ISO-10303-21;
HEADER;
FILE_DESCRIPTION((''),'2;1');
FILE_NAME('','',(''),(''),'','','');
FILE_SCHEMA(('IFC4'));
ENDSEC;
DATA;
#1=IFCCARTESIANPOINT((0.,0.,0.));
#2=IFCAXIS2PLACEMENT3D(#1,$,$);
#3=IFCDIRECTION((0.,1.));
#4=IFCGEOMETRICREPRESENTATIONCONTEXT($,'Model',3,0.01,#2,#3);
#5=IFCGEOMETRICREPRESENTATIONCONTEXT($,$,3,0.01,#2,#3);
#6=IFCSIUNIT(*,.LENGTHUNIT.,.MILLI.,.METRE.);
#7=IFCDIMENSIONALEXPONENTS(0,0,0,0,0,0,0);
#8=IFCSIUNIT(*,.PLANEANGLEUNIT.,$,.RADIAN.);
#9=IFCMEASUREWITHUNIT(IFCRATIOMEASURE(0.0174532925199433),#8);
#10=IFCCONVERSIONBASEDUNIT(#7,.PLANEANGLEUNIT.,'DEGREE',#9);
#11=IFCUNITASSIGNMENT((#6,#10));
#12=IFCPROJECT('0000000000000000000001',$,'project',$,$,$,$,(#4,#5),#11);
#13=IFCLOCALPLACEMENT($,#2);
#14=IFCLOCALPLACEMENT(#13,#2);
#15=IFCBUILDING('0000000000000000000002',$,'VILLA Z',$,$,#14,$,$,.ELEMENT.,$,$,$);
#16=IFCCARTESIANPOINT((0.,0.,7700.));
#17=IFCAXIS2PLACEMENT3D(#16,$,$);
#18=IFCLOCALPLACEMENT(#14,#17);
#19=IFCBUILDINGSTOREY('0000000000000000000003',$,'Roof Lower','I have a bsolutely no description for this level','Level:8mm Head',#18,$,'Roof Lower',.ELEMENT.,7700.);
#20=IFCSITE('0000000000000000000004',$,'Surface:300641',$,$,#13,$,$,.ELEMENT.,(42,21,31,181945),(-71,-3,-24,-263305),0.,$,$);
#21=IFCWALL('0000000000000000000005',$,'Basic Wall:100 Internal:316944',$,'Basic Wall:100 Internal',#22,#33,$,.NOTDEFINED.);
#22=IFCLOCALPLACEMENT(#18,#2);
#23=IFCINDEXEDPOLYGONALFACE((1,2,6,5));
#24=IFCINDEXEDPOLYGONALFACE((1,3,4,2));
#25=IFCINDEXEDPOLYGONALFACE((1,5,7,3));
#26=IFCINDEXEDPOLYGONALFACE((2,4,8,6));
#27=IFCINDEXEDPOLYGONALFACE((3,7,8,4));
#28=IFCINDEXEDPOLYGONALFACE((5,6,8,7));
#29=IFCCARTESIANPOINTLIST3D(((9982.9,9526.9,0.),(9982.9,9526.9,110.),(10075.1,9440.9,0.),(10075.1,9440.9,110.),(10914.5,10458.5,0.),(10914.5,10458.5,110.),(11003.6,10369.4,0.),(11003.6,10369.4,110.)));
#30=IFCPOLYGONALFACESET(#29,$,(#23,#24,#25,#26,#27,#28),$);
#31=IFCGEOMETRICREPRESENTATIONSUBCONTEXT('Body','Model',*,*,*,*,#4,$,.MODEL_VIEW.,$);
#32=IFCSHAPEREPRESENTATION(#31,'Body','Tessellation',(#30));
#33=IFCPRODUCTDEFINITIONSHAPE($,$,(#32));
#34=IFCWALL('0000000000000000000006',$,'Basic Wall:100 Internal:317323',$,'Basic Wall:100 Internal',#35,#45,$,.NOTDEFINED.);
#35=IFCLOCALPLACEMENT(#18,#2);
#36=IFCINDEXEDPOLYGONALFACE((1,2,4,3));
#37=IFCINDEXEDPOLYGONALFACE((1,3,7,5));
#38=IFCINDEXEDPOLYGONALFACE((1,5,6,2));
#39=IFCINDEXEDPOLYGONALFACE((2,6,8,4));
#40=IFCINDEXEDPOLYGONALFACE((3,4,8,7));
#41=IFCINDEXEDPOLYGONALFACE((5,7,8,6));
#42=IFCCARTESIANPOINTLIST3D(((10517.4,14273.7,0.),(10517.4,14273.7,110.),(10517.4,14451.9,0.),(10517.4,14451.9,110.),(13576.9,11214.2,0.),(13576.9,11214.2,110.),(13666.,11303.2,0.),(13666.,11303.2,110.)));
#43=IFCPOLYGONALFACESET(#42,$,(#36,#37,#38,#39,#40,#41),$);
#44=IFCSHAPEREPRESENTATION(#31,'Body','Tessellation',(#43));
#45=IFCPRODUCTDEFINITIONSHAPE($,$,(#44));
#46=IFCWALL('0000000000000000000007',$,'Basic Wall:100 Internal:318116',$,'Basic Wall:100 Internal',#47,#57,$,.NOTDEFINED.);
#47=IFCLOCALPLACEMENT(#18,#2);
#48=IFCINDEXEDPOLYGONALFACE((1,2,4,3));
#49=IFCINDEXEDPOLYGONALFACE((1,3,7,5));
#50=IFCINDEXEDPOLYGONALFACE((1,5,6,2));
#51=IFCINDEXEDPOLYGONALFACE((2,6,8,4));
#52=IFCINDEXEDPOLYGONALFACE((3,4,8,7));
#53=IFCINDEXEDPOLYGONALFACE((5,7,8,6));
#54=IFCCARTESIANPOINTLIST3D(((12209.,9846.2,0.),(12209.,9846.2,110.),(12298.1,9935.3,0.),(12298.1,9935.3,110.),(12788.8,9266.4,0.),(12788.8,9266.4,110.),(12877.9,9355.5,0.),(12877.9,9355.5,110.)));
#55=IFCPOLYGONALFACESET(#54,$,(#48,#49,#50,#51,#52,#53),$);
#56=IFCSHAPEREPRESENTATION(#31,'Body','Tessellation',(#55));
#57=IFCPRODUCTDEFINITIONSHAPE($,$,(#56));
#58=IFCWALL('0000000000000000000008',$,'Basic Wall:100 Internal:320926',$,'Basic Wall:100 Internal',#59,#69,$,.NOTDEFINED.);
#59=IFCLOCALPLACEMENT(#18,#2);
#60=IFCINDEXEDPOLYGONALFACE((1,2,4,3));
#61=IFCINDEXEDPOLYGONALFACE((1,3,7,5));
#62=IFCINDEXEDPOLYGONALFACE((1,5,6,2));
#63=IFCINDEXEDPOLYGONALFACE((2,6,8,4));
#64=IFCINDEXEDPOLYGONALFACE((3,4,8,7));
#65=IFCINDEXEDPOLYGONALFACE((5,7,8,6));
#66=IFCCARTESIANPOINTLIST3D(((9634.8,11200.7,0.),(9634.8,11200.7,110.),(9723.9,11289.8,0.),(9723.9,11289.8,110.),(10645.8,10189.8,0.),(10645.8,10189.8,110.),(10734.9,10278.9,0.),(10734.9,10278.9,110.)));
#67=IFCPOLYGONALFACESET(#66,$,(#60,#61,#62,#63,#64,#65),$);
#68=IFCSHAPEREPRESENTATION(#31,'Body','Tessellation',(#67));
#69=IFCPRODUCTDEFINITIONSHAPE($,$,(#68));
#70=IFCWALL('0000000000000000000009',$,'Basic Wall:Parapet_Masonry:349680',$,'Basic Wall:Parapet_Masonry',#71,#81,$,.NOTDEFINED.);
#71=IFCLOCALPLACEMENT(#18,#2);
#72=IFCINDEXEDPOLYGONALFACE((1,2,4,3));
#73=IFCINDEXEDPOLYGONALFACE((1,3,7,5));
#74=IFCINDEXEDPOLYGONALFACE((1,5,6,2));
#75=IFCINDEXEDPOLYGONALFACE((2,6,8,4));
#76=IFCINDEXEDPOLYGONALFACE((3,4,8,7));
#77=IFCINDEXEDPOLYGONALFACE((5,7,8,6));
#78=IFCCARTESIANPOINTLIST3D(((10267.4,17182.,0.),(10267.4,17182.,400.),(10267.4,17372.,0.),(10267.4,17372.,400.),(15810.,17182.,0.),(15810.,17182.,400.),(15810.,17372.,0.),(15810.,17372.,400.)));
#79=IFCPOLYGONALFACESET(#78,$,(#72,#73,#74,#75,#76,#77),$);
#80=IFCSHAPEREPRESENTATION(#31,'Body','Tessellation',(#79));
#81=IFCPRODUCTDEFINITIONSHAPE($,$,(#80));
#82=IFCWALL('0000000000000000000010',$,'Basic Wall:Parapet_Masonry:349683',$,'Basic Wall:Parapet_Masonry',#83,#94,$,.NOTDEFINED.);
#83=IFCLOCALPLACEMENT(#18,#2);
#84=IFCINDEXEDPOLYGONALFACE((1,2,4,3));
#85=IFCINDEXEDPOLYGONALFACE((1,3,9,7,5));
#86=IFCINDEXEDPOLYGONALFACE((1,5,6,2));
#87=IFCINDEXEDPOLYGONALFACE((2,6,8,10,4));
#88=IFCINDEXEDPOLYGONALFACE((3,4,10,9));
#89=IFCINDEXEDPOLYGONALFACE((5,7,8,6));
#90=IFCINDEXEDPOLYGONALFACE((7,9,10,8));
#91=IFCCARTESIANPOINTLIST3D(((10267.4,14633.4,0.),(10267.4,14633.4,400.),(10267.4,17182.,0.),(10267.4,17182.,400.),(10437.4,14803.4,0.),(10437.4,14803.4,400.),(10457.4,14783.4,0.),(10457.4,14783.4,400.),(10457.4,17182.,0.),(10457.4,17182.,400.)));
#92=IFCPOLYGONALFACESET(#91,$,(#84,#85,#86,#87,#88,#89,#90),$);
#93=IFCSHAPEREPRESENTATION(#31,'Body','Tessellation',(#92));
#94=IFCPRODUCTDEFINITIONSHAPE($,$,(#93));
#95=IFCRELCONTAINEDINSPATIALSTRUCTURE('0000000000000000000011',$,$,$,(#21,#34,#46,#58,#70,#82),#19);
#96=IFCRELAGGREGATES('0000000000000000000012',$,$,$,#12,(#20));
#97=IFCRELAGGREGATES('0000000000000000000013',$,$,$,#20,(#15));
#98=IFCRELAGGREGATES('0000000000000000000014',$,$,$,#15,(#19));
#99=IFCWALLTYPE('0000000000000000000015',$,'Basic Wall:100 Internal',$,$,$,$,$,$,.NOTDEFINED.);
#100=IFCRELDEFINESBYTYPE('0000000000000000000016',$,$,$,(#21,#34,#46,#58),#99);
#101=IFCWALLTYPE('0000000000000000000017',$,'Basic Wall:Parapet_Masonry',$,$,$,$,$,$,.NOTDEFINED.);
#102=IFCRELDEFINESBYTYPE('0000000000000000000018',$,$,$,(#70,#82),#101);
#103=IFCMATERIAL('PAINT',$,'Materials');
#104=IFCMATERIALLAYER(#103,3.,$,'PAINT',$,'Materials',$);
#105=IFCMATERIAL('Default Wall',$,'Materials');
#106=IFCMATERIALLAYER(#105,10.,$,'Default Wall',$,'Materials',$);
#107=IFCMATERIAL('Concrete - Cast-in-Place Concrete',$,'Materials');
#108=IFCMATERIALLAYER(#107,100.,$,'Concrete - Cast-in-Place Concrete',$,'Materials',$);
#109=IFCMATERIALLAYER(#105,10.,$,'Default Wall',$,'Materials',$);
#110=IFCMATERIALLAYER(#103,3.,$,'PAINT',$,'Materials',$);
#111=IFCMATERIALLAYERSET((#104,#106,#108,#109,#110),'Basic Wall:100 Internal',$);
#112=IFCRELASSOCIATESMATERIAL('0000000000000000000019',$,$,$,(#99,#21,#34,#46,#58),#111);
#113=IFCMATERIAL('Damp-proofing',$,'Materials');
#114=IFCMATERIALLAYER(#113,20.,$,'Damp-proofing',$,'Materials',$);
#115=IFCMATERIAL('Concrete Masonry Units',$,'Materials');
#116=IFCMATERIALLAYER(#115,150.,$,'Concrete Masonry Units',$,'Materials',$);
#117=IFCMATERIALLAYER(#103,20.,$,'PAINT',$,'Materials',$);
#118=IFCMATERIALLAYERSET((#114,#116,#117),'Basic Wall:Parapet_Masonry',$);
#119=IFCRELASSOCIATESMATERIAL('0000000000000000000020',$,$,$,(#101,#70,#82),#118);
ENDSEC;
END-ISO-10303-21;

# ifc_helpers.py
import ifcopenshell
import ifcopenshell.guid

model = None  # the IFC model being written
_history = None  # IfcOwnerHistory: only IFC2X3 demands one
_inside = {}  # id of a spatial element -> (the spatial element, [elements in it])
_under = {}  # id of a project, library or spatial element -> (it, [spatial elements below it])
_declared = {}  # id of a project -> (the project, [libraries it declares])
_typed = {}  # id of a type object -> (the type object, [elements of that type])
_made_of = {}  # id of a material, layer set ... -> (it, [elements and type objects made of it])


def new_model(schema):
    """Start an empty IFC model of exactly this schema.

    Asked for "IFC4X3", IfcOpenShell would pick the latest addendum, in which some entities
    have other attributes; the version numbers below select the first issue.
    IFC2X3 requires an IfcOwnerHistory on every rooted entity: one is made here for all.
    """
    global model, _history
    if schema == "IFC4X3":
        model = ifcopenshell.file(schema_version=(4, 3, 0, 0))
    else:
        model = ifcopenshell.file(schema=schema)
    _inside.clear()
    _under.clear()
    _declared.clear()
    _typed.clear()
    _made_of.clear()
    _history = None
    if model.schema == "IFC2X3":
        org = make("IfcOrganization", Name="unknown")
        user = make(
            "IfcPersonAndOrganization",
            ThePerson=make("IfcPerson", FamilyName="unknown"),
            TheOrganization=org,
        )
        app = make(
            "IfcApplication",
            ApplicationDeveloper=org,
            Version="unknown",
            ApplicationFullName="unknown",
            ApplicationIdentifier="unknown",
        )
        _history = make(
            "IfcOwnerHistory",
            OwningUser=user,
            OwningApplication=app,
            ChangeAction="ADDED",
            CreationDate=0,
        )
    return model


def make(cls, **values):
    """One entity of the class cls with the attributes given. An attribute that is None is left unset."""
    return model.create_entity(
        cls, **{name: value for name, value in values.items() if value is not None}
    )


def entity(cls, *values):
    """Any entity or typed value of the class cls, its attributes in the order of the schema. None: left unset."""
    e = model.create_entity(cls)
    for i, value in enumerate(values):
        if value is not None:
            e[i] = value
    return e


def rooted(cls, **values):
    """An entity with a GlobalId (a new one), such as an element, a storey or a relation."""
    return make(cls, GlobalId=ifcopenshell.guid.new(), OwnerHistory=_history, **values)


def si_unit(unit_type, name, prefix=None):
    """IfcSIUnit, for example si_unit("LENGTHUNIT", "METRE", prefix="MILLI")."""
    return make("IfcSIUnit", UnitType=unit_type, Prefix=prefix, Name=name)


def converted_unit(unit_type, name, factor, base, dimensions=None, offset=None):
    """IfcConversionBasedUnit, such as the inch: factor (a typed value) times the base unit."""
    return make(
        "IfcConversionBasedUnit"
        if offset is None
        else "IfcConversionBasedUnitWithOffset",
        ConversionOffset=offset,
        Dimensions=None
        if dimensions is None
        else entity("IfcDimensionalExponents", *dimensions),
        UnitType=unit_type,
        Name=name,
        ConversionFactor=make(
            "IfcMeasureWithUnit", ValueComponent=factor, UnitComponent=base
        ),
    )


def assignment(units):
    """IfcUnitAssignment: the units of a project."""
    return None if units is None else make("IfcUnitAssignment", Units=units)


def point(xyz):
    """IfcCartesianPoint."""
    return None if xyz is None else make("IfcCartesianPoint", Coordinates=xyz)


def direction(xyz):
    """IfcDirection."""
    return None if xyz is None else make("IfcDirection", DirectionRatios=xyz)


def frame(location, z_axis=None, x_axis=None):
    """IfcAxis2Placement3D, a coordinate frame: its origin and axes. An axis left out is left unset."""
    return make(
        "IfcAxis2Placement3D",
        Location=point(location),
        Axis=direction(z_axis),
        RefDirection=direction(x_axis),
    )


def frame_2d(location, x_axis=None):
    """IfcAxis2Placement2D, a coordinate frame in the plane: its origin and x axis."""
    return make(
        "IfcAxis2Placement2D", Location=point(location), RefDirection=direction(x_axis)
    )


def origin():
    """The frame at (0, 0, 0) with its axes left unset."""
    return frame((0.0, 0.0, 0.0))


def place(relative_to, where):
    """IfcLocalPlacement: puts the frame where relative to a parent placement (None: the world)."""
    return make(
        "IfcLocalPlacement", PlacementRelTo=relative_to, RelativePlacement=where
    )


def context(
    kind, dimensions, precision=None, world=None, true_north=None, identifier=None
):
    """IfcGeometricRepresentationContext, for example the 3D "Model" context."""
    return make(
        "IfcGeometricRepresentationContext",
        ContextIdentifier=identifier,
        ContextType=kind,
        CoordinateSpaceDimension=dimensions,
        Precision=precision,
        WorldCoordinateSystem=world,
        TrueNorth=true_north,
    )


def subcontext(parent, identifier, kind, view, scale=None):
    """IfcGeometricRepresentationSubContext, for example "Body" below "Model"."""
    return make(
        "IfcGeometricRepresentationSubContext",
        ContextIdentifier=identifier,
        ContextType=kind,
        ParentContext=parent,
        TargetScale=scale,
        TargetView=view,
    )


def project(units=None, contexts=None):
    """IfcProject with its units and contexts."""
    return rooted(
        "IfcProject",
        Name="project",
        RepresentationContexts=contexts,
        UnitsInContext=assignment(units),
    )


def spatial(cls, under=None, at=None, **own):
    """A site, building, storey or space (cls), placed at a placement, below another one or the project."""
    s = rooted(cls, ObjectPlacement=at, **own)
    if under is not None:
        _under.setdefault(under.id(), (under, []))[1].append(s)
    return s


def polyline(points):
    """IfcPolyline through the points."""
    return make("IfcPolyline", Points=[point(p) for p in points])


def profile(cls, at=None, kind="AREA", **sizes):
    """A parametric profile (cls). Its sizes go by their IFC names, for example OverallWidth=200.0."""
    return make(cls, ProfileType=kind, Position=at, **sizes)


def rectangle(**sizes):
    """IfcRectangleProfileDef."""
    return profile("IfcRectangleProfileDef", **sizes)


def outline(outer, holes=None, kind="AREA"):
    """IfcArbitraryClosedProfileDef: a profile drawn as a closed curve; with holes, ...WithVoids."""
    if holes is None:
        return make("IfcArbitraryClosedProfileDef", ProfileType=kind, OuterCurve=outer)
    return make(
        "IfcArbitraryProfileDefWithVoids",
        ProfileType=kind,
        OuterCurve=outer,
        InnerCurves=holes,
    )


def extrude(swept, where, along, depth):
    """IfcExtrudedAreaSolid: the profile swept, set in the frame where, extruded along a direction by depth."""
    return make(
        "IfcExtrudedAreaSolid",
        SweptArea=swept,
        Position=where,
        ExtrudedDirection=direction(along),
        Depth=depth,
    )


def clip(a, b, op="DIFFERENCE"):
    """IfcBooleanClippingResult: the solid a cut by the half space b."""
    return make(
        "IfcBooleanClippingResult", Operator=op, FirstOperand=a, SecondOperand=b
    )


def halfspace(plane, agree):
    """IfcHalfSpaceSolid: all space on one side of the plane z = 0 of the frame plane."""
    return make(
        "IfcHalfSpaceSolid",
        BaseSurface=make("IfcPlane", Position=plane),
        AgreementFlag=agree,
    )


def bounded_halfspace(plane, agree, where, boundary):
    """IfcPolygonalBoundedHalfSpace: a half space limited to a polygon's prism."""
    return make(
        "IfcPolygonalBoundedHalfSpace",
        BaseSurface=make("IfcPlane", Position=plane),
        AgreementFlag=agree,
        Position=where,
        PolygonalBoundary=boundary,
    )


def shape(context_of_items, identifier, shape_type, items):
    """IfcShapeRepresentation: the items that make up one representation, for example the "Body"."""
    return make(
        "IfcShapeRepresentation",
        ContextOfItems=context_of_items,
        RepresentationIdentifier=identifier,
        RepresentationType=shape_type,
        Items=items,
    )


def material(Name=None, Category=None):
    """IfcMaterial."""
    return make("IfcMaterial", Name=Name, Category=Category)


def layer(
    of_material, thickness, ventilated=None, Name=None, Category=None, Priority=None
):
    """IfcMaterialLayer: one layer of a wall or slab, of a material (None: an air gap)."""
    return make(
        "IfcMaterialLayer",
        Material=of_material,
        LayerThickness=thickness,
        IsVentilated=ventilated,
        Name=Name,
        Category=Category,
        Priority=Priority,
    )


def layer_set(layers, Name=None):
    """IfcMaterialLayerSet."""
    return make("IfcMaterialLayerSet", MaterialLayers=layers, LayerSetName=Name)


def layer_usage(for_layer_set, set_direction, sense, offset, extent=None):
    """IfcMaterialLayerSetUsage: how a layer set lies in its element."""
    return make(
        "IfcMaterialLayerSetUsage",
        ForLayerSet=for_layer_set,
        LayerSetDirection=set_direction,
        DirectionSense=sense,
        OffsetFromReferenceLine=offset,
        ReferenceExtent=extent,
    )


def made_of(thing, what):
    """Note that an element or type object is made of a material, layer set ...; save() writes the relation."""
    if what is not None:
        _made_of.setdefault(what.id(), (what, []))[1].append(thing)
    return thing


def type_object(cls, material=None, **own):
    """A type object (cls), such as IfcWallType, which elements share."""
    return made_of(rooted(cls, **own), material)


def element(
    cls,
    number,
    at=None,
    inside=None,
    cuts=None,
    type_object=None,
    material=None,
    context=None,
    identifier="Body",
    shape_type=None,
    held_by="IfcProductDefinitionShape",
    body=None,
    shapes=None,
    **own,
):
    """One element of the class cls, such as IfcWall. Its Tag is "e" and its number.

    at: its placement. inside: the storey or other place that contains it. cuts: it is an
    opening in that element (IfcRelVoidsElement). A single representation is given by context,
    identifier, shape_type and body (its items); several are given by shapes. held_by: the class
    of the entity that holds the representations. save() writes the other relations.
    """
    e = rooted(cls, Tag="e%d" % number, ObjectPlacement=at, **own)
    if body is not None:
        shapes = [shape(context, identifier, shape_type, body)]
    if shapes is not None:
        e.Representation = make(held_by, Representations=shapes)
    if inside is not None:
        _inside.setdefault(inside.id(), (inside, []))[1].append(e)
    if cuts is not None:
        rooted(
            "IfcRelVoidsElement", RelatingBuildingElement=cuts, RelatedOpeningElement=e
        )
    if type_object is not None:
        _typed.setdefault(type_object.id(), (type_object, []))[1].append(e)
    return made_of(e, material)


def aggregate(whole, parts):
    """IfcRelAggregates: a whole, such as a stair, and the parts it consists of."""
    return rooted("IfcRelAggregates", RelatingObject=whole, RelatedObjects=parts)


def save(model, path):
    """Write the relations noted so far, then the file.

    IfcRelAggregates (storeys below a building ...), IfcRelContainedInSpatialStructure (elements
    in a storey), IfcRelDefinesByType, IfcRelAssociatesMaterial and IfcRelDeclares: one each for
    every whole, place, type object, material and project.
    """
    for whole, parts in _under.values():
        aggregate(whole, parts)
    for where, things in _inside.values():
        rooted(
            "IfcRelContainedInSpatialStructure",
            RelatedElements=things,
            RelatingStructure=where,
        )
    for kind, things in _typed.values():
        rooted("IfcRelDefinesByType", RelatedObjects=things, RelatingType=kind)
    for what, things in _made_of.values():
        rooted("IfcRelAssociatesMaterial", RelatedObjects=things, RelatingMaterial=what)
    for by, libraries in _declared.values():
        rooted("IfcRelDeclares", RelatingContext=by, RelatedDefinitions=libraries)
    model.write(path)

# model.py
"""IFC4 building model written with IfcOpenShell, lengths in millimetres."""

from ifc_helpers import new_model, entity, si_unit, converted_unit, direction, frame, frame_2d, origin, place, context, subcontext, project, spatial, polyline, rectangle, outline, extrude, clip, halfspace, bounded_halfspace, material, layer, layer_set, layer_usage, type_object, element, save


model = new_model("IFC4")

# Units and contexts
model_context = context("Model", 3, precision=0.01, world=origin(), true_north=direction((0.0, 1.0)))
context_of_model = context(None, 3, precision=0.01, world=origin(), true_north=direction((0.0, 1.0)))
body_context = subcontext(model_context, "Body", "Model", "MODEL_VIEW")
ifc_project = project(units=[si_unit("LENGTHUNIT", "METRE", prefix="MILLI"), converted_unit("PLANEANGLEUNIT", "DEGREE", entity("IfcRatioMeasure", 0.0174532925199433), si_unit("PLANEANGLEUNIT", "RADIAN"), dimensions=[0, 0, 0, 0, 0, 0, 0])], contexts=[model_context, context_of_model])

# Site, building, storey
site_placement = place(None, origin())
site = spatial("IfcSite", under=ifc_project, at=site_placement, Name="Surface:300641", CompositionType="ELEMENT", RefLatitude=(42, 21, 31, 181945), RefLongitude=(-71, -3, -24, -263305), RefElevation=0.0)
building_placement = place(site_placement, origin())
building = spatial("IfcBuilding", under=site, at=building_placement, Name="VILLA Z", CompositionType="ELEMENT")
storey_placement = place(building_placement, frame((0.0, 0.0, 7700.0)))
storey = spatial("IfcBuildingStorey", under=building, at=storey_placement, Name="Roof Lower", Description="I have a bsolutely no description for this level", ObjectType="Level:8mm Head", LongName="Roof Lower", CompositionType="ELEMENT", Elevation=7700.0)

# Shared definitions
ifc_material_1 = material(Name="Concrete - Cast-in-Place Concrete", Category="Materials")

# Walls
ifc_material_2 = material(Name="PAINT", Category="Materials")
ifc_material_3 = material(Name="Default Wall", Category="Materials")
ifc_layer_1 = layer(ifc_material_2, 3.0, Name="PAINT", Category="Materials")
ifc_layer_2 = layer(ifc_material_3, 10.0, Name="Default Wall", Category="Materials")
ifc_layer_3 = layer(ifc_material_1, 100.0, Name="Concrete - Cast-in-Place Concrete", Category="Materials")
ifc_layer_4 = layer(ifc_material_3, 10.0, Name="Default Wall", Category="Materials")
ifc_layer_5 = layer(ifc_material_2, 3.0, Name="PAINT", Category="Materials")
ifc_layer_set_1 = layer_set([ifc_layer_1, ifc_layer_2, ifc_layer_3, ifc_layer_4, ifc_layer_5], Name="Basic Wall:100 Internal")
wall_type_1 = type_object("IfcWallType", Name="Basic Wall:100 Internal", PredefinedType="NOTDEFINED", material=ifc_layer_set_1)
ifc_layer_usage_1 = layer_usage(ifc_layer_set_1, "AXIS2", "NEGATIVE", 63.0)
wall_1_placement = place(storey_placement, frame((10959.0, 10413.9, 0.0), z_axis=(0.0, 0.0, 1.0), x_axis=(-0.707107, -0.707107, 0.0)))
element("IfcWall", 1, at=wall_1_placement, inside=storey, type_object=wall_type_1, material=ifc_layer_usage_1, Name="Basic Wall:100 Internal:316944", ObjectType="Basic Wall:100 Internal", PredefinedType="NOTDEFINED", context=body_context, shape_type="Clipping", body=[
    clip(clip(extrude(outline(polyline([(0.0, -63.0), (254.0, -63.0), (380.0, -63.0), (1317.4, -63.0), (1313.0, 63.0), (0.0, 63.0), (0.0, -63.0)])), origin(), (0.0, 0.0, 1.0), 110.0), bounded_halfspace(frame((0.0, -63.0, 110.0), z_axis=(0.0, 0.0, -1.0), x_axis=(-0.707107, 0.707107, 0.0)), True, frame((0.0, -63.0, 110.0)), polyline([(0.0, 0.0), (254.0, 0.0), (380.0, 0.0), (1317.4, 0.0), (1313.0, 126.0), (0.0, 126.0), (0.0, 0.0)]))), halfspace(frame((0.0, 0.0, -3500.0)), True)),
])
ifc_layer_usage_2 = layer_usage(ifc_layer_set_1, "AXIS2", "NEGATIVE", 63.0)
wall_2_placement = place(storey_placement, frame((10472.8, 14407.3, 0.0), z_axis=(0.0, 0.0, 1.0), x_axis=(0.707107, -0.707107, 0.0)))
element("IfcWall", 2, at=wall_2_placement, inside=storey, type_object=wall_type_1, material=ifc_layer_usage_2, Name="Basic Wall:100 Internal:317323", ObjectType="Basic Wall:100 Internal", PredefinedType="NOTDEFINED", context=body_context, shape_type="Clipping", body=[
    clip(clip(extrude(outline(polyline([(126.0, -63.0), (1424.8, -63.0), (1674.8, -63.0), (4326.8, -63.0), (4452.8, -63.0), (4452.8, 63.0), (0.0, 63.0), (126.0, -63.0)])), origin(), (0.0, 0.0, 1.0), 110.0), bounded_halfspace(frame((126.0, -63.0, 110.0), z_axis=(0.0, 0.0, -1.0), x_axis=(0.707107, 0.707107, 0.0)), True, frame((126.0, -63.0, 110.0)), polyline([(0.0, 0.0), (1298.8, 0.0), (1548.8, 0.0), (4200.8, 0.0), (4326.8, 0.0), (4326.8, 126.0), (-126.0, 126.0), (0.0, 0.0)]))), halfspace(frame((0.0, 0.0, -3500.0)), True)),
])
ifc_layer_usage_3 = layer_usage(ifc_layer_set_1, "AXIS2", "NEGATIVE", 63.0)
wall_3_placement = place(storey_placement, frame((12253.5, 9890.7, 0.0), z_axis=(0.0, 0.0, 1.0), x_axis=(0.707107, -0.707107, 0.0)))
element("IfcWall", 3, at=wall_3_placement, inside=storey, type_object=wall_type_1, material=ifc_layer_usage_3, Name="Basic Wall:100 Internal:318116", ObjectType="Basic Wall:100 Internal", PredefinedType="NOTDEFINED", context=body_context, shape_type="Clipping", body=[
    clip(clip(extrude(rectangle(XDim=820.0, YDim=126.0, at=frame_2d((410.0, 0.0), x_axis=(-1.0, 0.0))), origin(), (0.0, 0.0, 1.0), 110.0), bounded_halfspace(frame((0.0, -63.0, 110.0), z_axis=(0.0, 0.0, -1.0), x_axis=(0.707107, 0.707107, 0.0)), True, frame((0.0, -63.0, 110.0)), polyline([(0.0, 0.0), (694.0, 0.0), (820.0, 0.0), (820.0, 126.0), (0.0, 126.0), (0.0, 0.0)]))), halfspace(frame((0.0, 0.0, -3500.0)), True)),
])
ifc_layer_usage_4 = layer_usage(ifc_layer_set_1, "AXIS2", "NEGATIVE", 63.0)
wall_4_placement = place(storey_placement, frame((10690.3, 10234.3, 0.0), z_axis=(0.0, 0.0, 1.0), x_axis=(-0.707107, 0.707107, 0.0)))
element("IfcWall", 4, at=wall_4_placement, inside=storey, type_object=wall_type_1, material=ifc_layer_usage_4, Name="Basic Wall:100 Internal:320926", ObjectType="Basic Wall:100 Internal", PredefinedType="NOTDEFINED", context=body_context, shape_type="Clipping", body=[
    clip(clip(extrude(rectangle(XDim=1429.7, YDim=126.0, at=frame_2d((714.9, 0.0), x_axis=(-1.0, 0.0))), origin(), (0.0, 0.0, 1.0), 110.0), bounded_halfspace(frame((0.0, -63.0, 110.0), z_axis=(0.0, 0.0, -1.0), x_axis=(-0.707107, -0.707107, 0.0)), True, frame((0.0, -63.0, 110.0)), polyline([(0.0, 0.0), (1429.7, 0.0), (1429.7, 125.0), (1429.7, 126.0), (0.0, 126.0), (0.0, 0.0)]))), halfspace(frame((0.0, 0.0, -3500.0)), True)),
])
ifc_material_4 = material(Name="Damp-proofing", Category="Materials")
ifc_layer_6 = layer(ifc_material_4, 20.0, Name="Damp-proofing", Category="Materials")
ifc_material_5 = material(Name="Concrete Masonry Units", Category="Materials")
ifc_layer_7 = layer(ifc_material_5, 150.0, Name="Concrete Masonry Units", Category="Materials")
ifc_layer_8 = layer(ifc_material_2, 20.0, Name="PAINT", Category="Materials")
ifc_layer_set_2 = layer_set([ifc_layer_6, ifc_layer_7, ifc_layer_8], Name="Basic Wall:Parapet_Masonry")
ifc_layer_usage_5 = layer_usage(ifc_layer_set_2, "AXIS2", "NEGATIVE", 95.0)
wall_type_2 = type_object("IfcWallType", Name="Basic Wall:Parapet_Masonry", PredefinedType="NOTDEFINED", material=ifc_layer_set_2)
wall_5_placement = place(storey_placement, frame((15810.0, 17277.0, 0.0), z_axis=(0.0, 0.0, 1.0), x_axis=(-1.0, 0.0, 0.0)))
element("IfcWall", 5, at=wall_5_placement, inside=storey, type_object=wall_type_2, material=ifc_layer_usage_5, Name="Basic Wall:Parapet_Masonry:349680", ObjectType="Basic Wall:Parapet_Masonry", PredefinedType="NOTDEFINED", context=body_context, shape_type="Clipping", body=[
    clip(extrude(rectangle(XDim=5542.6, YDim=190.0, at=frame_2d((2771.3, 0.0), x_axis=(-1.0, 0.0))), origin(), (0.0, 0.0, 1.0), 400.0), halfspace(origin(), True)),
])
ifc_layer_usage_6 = layer_usage(ifc_layer_set_2, "AXIS2", "NEGATIVE", 95.0)
wall_6_placement = place(storey_placement, frame((10362.4, 17182.0, 0.0), z_axis=(0.0, 0.0, 1.0), x_axis=(0.0, -1.0, 0.0)))
element("IfcWall", 6, at=wall_6_placement, inside=storey, type_object=wall_type_2, material=ifc_layer_usage_6, Name="Basic Wall:Parapet_Masonry:349683", ObjectType="Basic Wall:Parapet_Masonry", PredefinedType="NOTDEFINED", context=body_context, shape_type="Clipping", body=[
    clip(extrude(outline(polyline([(2548.6, -95.0), (2378.6, 75.0), (2398.6, 95.0), (0.0, 95.0), (0.0, -95.0), (2548.6, -95.0)])), origin(), (0.0, 0.0, 1.0), 400.0), halfspace(origin(), True)),
])

save(model, "model.ifc")
